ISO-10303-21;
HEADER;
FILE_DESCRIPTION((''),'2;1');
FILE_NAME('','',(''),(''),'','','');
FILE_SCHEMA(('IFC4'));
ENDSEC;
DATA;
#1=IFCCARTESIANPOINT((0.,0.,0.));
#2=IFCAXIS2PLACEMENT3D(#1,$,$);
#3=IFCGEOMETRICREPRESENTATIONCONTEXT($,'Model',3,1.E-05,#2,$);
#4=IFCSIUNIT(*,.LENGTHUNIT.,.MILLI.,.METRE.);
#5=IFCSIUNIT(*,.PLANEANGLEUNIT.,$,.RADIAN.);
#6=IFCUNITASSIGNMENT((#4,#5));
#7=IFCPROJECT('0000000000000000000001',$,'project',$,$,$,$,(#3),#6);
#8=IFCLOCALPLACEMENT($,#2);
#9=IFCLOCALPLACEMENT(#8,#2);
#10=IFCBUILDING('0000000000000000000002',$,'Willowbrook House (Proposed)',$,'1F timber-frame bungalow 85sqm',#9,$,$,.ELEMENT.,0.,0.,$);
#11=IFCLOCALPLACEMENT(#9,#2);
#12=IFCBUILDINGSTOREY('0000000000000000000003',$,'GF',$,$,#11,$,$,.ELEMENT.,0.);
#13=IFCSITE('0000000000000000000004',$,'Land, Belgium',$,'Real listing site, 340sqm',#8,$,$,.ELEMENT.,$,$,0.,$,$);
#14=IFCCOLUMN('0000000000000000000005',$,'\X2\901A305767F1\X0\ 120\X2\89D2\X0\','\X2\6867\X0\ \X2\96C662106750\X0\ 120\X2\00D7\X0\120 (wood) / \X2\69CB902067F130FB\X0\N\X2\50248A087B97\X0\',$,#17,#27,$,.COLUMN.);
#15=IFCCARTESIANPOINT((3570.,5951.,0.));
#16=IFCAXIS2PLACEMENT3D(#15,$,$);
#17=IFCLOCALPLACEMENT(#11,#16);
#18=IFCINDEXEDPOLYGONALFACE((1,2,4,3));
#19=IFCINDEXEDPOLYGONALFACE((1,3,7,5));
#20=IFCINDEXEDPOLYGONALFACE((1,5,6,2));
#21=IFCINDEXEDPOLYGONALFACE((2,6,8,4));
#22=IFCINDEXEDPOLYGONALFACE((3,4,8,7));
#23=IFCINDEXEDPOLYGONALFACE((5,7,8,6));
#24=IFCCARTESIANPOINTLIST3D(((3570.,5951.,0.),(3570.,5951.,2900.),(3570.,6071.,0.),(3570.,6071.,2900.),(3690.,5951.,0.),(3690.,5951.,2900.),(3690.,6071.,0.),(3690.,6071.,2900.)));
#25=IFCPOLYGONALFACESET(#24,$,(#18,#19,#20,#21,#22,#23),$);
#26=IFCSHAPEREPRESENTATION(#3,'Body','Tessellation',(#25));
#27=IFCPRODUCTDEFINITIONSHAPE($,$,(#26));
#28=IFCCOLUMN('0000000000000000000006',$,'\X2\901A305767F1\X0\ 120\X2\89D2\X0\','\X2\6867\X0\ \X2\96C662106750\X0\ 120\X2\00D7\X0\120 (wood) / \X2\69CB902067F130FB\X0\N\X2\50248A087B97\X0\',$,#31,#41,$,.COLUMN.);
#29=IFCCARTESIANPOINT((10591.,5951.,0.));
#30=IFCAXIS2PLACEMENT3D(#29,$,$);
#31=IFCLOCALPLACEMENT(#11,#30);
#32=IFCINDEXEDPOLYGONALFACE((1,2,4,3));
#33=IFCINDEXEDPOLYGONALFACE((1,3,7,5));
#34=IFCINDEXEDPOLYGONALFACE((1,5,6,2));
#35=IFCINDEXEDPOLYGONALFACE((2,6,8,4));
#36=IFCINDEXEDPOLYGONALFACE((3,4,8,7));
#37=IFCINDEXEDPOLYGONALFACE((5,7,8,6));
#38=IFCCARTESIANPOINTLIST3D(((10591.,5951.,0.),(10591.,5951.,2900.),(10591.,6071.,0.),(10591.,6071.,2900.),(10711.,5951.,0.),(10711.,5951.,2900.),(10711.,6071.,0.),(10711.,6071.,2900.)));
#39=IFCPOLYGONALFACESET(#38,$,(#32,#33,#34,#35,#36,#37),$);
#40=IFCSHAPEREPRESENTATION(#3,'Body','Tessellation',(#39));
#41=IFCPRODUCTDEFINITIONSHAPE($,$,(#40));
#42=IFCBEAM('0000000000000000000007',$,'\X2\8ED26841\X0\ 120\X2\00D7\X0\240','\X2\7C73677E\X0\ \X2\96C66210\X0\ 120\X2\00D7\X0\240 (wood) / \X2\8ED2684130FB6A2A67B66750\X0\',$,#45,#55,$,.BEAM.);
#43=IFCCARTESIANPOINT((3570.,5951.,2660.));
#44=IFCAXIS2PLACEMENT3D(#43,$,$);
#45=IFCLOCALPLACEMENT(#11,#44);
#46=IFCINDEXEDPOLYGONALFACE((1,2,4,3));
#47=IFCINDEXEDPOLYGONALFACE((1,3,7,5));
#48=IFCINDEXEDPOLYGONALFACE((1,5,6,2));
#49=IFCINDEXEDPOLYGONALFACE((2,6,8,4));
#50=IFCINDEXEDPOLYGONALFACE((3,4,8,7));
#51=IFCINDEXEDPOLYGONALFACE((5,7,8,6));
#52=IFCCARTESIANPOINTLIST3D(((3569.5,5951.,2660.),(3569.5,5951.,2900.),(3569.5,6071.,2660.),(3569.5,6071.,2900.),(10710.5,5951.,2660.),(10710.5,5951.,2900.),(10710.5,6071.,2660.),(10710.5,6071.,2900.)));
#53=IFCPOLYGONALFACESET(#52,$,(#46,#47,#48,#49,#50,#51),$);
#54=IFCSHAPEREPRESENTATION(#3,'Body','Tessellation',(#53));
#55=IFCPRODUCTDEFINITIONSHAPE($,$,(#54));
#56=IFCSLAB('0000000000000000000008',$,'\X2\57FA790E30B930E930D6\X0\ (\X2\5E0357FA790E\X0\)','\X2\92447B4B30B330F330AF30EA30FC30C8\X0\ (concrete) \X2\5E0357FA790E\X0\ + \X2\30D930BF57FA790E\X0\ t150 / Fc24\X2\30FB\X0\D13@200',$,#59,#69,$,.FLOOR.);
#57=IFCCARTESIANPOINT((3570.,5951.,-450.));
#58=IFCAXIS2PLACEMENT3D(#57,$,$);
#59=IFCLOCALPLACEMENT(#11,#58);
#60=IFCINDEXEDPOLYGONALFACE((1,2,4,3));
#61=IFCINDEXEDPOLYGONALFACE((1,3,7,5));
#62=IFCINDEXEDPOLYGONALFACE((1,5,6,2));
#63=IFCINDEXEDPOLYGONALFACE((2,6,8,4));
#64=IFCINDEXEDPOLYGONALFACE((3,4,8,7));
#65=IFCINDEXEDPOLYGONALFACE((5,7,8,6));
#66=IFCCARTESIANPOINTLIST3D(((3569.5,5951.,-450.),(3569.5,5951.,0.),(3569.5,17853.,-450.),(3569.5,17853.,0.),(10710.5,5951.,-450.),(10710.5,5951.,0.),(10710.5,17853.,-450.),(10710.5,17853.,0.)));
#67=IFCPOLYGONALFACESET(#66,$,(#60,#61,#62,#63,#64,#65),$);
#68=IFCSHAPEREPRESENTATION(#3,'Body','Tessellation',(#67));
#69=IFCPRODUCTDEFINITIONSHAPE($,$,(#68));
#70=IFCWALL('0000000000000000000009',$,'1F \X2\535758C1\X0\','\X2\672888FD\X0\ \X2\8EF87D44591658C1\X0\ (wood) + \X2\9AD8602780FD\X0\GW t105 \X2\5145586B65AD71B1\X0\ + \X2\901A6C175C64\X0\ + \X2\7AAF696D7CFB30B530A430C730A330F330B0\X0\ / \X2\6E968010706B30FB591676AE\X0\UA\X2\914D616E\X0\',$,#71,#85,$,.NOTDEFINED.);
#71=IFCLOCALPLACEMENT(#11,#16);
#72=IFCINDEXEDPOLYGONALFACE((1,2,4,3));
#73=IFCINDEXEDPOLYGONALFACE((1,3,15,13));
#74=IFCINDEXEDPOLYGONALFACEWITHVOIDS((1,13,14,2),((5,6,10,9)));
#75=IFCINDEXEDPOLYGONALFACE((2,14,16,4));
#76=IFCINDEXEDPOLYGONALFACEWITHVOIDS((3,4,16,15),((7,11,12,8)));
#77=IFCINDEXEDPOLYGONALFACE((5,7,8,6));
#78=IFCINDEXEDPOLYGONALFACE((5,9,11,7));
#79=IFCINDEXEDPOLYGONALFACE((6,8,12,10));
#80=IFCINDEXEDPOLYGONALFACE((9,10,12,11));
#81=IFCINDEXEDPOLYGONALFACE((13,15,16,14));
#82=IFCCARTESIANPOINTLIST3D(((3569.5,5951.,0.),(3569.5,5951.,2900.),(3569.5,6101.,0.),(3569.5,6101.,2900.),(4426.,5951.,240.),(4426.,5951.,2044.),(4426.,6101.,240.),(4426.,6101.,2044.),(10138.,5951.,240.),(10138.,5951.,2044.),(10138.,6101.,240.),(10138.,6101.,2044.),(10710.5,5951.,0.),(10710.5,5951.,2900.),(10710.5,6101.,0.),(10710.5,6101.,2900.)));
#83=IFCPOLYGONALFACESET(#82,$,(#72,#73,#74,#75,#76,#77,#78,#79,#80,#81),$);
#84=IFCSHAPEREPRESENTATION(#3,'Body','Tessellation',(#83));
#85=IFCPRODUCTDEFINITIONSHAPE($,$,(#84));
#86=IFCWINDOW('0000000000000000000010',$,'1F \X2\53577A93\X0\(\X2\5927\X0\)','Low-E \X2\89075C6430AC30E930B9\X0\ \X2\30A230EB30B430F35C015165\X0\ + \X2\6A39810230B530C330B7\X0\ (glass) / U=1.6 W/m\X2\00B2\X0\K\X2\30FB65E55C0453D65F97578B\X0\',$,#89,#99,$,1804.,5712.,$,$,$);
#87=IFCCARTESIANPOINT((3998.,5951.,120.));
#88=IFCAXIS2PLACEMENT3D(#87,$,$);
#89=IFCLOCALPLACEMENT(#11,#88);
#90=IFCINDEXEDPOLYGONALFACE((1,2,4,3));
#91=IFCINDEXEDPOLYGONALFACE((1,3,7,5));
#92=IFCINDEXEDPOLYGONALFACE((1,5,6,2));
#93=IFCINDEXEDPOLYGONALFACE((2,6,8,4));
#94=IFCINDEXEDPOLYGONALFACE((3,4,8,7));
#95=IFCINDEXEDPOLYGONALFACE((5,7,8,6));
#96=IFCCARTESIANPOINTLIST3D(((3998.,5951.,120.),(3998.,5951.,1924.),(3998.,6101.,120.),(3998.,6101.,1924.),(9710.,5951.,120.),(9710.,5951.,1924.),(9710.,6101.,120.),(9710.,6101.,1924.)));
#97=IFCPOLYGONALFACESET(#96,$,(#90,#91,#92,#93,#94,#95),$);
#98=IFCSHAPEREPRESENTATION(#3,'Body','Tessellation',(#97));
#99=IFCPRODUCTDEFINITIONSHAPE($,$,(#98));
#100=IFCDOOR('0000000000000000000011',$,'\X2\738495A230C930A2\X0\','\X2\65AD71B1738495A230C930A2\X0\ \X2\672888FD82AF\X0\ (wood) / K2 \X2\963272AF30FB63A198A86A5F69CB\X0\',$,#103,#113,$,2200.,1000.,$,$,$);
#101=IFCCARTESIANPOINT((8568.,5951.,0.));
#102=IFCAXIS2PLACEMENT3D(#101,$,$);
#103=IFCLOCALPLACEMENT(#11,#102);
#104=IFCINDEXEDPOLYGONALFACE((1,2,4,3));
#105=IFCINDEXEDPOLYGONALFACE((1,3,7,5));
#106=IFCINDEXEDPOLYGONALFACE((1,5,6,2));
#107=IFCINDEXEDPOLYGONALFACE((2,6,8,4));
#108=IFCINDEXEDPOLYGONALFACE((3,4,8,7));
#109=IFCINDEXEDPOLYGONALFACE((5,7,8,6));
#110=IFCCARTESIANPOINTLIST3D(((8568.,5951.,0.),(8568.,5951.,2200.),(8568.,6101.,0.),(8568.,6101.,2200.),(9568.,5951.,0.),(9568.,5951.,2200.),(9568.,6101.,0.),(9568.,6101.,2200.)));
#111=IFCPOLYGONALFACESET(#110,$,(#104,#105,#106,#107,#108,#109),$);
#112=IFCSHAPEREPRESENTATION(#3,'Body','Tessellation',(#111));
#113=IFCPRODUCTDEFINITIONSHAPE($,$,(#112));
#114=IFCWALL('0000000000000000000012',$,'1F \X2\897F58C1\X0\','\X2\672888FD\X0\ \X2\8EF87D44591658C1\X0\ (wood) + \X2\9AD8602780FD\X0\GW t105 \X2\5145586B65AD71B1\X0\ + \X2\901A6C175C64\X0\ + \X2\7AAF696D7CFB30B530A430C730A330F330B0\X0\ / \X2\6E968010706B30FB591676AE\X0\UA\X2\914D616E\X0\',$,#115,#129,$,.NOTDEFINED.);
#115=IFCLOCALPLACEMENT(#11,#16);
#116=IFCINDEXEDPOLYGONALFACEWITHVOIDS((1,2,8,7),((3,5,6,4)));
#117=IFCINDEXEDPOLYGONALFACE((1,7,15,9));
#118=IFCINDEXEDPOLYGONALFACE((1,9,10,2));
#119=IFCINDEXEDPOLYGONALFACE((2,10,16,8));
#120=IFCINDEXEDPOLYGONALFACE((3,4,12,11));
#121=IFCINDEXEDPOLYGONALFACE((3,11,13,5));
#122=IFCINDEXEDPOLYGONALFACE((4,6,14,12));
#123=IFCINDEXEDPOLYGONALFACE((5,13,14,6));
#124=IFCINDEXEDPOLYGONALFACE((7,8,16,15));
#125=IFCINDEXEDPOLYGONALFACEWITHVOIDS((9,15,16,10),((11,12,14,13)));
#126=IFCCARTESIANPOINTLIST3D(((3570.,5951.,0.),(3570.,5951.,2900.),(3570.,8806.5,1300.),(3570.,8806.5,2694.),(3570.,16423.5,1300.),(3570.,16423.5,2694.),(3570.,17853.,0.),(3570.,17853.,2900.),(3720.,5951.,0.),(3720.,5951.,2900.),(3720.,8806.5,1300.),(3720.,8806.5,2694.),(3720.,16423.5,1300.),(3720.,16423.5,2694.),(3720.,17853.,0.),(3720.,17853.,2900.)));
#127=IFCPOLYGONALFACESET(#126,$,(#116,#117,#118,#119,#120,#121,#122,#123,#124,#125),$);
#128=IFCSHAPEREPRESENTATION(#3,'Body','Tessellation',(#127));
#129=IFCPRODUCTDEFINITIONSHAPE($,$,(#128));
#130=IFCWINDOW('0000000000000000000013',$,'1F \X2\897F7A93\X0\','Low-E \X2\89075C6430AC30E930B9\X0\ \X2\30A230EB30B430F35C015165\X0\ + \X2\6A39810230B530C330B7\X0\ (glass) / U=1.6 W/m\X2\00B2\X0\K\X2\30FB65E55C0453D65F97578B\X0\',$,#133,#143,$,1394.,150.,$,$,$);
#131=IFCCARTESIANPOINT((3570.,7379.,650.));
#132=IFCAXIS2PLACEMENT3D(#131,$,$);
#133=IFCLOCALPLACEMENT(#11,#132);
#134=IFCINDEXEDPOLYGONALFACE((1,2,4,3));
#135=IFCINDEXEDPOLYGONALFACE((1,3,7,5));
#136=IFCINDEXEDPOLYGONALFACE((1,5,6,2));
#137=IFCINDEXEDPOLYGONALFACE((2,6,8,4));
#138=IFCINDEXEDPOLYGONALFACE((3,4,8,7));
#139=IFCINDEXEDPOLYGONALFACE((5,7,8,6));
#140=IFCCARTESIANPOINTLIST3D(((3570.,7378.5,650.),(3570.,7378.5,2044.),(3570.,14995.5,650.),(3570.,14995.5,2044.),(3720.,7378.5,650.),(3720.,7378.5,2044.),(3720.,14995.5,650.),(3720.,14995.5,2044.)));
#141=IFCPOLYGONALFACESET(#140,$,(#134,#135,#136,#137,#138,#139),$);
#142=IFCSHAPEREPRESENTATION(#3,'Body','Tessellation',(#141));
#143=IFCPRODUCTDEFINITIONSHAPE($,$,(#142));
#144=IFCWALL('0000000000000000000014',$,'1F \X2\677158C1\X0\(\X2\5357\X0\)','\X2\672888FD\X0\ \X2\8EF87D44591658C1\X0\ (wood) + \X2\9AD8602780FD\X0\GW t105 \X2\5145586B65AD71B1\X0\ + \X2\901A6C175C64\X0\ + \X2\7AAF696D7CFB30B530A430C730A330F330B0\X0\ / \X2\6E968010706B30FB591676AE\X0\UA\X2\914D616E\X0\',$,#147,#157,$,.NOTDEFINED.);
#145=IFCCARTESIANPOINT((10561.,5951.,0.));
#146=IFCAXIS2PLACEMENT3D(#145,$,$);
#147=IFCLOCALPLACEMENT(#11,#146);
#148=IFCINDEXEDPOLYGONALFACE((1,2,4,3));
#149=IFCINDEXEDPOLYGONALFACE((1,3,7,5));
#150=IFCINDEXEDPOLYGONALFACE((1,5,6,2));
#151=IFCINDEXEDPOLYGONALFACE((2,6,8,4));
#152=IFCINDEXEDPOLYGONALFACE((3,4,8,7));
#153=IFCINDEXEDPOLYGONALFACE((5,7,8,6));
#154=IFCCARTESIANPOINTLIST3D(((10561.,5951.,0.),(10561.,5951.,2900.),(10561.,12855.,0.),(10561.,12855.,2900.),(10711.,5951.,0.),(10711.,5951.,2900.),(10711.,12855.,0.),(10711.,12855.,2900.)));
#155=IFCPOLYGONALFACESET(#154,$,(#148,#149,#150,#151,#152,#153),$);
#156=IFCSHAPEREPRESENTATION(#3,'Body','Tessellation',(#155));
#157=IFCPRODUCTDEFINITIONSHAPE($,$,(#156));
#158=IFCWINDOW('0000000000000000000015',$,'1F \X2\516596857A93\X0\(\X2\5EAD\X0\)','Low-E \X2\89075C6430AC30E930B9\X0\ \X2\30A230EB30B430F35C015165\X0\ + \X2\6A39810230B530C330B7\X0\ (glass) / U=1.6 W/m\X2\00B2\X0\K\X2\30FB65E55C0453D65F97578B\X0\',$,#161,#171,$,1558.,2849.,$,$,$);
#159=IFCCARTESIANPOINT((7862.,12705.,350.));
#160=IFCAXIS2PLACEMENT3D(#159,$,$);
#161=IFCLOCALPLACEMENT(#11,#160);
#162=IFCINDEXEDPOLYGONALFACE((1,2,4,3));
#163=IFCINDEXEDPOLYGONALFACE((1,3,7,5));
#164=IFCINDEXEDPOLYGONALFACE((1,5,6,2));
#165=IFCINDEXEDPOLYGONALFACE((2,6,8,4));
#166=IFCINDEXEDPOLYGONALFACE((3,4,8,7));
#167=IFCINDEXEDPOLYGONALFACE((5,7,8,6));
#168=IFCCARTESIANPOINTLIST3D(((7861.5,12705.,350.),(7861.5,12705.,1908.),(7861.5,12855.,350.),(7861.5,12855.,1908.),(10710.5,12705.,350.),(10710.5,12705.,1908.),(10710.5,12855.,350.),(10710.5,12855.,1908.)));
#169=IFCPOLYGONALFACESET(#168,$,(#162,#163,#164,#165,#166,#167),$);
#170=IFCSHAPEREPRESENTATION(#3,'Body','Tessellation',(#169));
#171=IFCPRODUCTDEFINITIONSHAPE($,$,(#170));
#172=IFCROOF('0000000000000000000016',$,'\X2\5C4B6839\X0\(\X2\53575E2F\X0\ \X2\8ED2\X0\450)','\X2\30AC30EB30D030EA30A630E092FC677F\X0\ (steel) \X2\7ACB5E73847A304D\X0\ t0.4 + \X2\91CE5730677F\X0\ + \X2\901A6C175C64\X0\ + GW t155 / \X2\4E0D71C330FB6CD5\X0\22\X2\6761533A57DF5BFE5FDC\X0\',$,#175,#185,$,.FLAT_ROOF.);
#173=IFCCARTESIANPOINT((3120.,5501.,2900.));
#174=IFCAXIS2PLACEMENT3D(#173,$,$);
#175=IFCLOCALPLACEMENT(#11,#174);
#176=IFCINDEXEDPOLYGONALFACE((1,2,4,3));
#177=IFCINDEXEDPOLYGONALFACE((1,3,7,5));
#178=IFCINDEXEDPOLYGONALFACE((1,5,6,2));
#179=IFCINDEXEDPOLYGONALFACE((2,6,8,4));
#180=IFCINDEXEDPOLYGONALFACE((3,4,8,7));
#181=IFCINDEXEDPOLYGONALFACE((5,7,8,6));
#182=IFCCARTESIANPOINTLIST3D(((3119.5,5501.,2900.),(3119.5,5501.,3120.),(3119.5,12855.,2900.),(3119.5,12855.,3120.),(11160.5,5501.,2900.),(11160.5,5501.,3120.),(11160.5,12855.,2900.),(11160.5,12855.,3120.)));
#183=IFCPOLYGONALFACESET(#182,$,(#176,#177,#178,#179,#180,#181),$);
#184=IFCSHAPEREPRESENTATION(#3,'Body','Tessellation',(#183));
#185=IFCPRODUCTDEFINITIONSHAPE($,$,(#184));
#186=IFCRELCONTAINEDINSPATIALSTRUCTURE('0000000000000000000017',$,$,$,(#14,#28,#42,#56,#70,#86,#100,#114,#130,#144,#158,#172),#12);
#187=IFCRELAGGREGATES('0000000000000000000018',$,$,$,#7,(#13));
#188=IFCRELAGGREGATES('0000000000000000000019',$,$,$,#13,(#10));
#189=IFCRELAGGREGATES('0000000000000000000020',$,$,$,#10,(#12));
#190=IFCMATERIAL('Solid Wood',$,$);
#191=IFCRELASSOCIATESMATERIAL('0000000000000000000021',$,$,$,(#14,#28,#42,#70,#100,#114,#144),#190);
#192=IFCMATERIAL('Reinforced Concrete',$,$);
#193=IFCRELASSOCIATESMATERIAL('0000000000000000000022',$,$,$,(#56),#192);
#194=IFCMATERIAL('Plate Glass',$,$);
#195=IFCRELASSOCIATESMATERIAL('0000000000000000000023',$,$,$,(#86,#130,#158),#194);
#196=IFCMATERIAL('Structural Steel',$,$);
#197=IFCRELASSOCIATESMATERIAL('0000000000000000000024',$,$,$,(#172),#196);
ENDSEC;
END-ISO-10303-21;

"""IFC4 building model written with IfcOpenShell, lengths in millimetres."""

from ifc_helpers import new_model, si_unit, frame, frame_2d, origin, place, context, project, spatial, rectangle, extrude, material, element, fill, save


model = new_model("IFC4")

# Units and contexts
model_context = context("Model", 3, precision=1e-05, world=origin())
ifc_project = project(units=[si_unit("LENGTHUNIT", "METRE", prefix="MILLI"), si_unit("PLANEANGLEUNIT", "RADIAN")], contexts=[model_context])

# Site, building, storey
site_placement = place(None, origin())
site = spatial("IfcSite", under=ifc_project, at=site_placement, Name="Land, Belgium", ObjectType="Real listing site, 340sqm", CompositionType="ELEMENT", RefElevation=0.0)
building_placement = place(site_placement, origin())
building = spatial("IfcBuilding", under=site, at=building_placement, Name="Willowbrook House (Proposed)", ObjectType="1F timber-frame bungalow 85sqm", CompositionType="ELEMENT", ElevationOfRefHeight=0.0, ElevationOfTerrain=0.0)
storey_placement = place(building_placement, origin())
storey = spatial("IfcBuildingStorey", under=building, at=storey_placement, Name="GF", CompositionType="ELEMENT", Elevation=0.0)

# Columns
ifc_material_1 = material(Name="Solid Wood")
column_1_placement = place(storey_placement, frame((3570.0, 5951.0, 0.0)))
element("IfcColumn", 1, at=column_1_placement, inside=storey, material=ifc_material_1, Name="通し柱 120角", Description="桧 集成材 120×120 (wood) / 構造柱・N値計算", PredefinedType="COLUMN", context=model_context, shape_type="SweptSolid", body=[
    extrude(rectangle(XDim=120.0, YDim=120.0, at=frame_2d((60.0, 60.0))), frame((3570.0, 5951.0, 0.0)), (0.0, 0.0, 1.0), 2900.0),
])
column_2_placement = place(storey_placement, frame((10591.0, 5951.0, 0.0)))
element("IfcColumn", 2, at=column_2_placement, inside=storey, material=ifc_material_1, Name="通し柱 120角", Description="桧 集成材 120×120 (wood) / 構造柱・N値計算", PredefinedType="COLUMN", context=model_context, shape_type="SweptSolid", body=[
    extrude(rectangle(XDim=120.0, YDim=120.0, at=frame_2d((60.0, 60.0))), frame((10591.0, 5951.0, 0.0)), (0.0, 0.0, 1.0), 2900.0),
])

# Beam
beam_1_placement = place(storey_placement, frame((3570.0, 5951.0, 2660.0)))
element("IfcBeam", 3, at=beam_1_placement, inside=storey, material=ifc_material_1, Name="軒桁 120×240", Description="米松 集成 120×240 (wood) / 軒桁・横架材", PredefinedType="BEAM", context=model_context, shape_type="SweptSolid", body=[
    extrude(rectangle(XDim=7141.0, YDim=120.0, at=frame_2d((3570.0, 60.0))), frame((3570.0, 5951.0, 2660.0)), (0.0, 0.0, 1.0), 240.0),
])

# Slab
ifc_material_2 = material(Name="Reinforced Concrete")
slab_1_placement = place(storey_placement, frame((3570.0, 5951.0, -450.0)))
element("IfcSlab", 4, at=slab_1_placement, inside=storey, material=ifc_material_2, Name="基礎スラブ (布基礎)", Description="鉄筋コンクリート (concrete) 布基礎 + ベタ基礎 t150 / Fc24・D13@200", PredefinedType="FLOOR", context=model_context, shape_type="SweptSolid", body=[
    extrude(rectangle(XDim=7141.0, YDim=11902.0, at=frame_2d((3570.0, 5951.0))), frame((3570.0, 5951.0, -450.0)), (0.0, 0.0, 1.0), 450.0),
])

# Wall, openings, window, door
wall_1_placement = place(storey_placement, frame((3570.0, 5951.0, 0.0)))
wall_1 = element("IfcWall", 5, at=wall_1_placement, inside=storey, material=ifc_material_1, Name="1F 南壁", Description="木製 軸組外壁 (wood) + 高性能GW t105 充填断熱 + 通気層 + 窯業系サイディング / 準耐火・外皮UA配慮", PredefinedType="NOTDEFINED", context=model_context, shape_type="SweptSolid", body=[
    extrude(rectangle(XDim=7141.0, YDim=150.0, at=frame_2d((3570.0, 75.0))), frame((3570.0, 5951.0, 0.0)), (0.0, 0.0, 1.0), 2900.0),
])
opening_1_placement = place(storey_placement, frame((3998.0, 5951.0, 120.0)))
opening_1 = element("IfcOpeningElement", 6, at=opening_1_placement, cuts=wall_1, PredefinedType="NOTDEFINED", context=model_context, shape_type="SweptSolid", body=[
    extrude(rectangle(XDim=5712.0, YDim=150.0, at=frame_2d((2856.0, 75.0))), frame((3998.0, 5951.0, 120.0)), (0.0, 0.0, 1.0), 1804.0),
])
opening_2_placement = place(storey_placement, frame((8568.0, 5951.0, 0.0)))
opening_2 = element("IfcOpeningElement", 7, at=opening_2_placement, cuts=wall_1, PredefinedType="NOTDEFINED", context=model_context, shape_type="SweptSolid", body=[
    extrude(rectangle(XDim=1000.0, YDim=150.0, at=frame_2d((500.0, 75.0))), frame((8568.0, 5951.0, 0.0)), (0.0, 0.0, 1.0), 2200.0),
])
ifc_material_3 = material(Name="Plate Glass")
window_1_placement = place(storey_placement, frame((3998.0, 5951.0, 120.0)))
window_1 = element("IfcWindow", 8, at=window_1_placement, inside=storey, material=ifc_material_3, Name="1F 南窓(大)", Description="Low-E 複層ガラス アルゴン封入 + 樹脂サッシ (glass) / U=1.6 W/m²K・日射取得型", OverallHeight=1804.0, OverallWidth=5712.0, context=model_context, shape_type="SweptSolid", body=[
    extrude(rectangle(XDim=5712.0, YDim=150.0, at=frame_2d((2856.0, 75.0))), frame((3998.0, 5951.0, 120.0)), (0.0, 0.0, 1.0), 1804.0),
])
fill(opening_1, window_1)
door_1_placement = place(storey_placement, frame((8568.0, 5951.0, 0.0)))
door_1 = element("IfcDoor", 9, at=door_1_placement, inside=storey, material=ifc_material_1, Name="玄関ドア", Description="断熱玄関ドア 木製芯 (wood) / K2 防犯・採風機構", OverallHeight=2200.0, OverallWidth=1000.0, context=model_context, shape_type="SweptSolid", body=[
    extrude(rectangle(XDim=1000.0, YDim=150.0, at=frame_2d((500.0, 75.0))), frame((8568.0, 5951.0, 0.0)), (0.0, 0.0, 1.0), 2200.0),
])
fill(opening_2, door_1)

# Walls, openings, windows
wall_2_placement = place(storey_placement, frame((3570.0, 5951.0, 0.0)))
wall_2 = element("IfcWall", 10, at=wall_2_placement, inside=storey, material=ifc_material_1, Name="1F 西壁", Description="木製 軸組外壁 (wood) + 高性能GW t105 充填断熱 + 通気層 + 窯業系サイディング / 準耐火・外皮UA配慮", PredefinedType="NOTDEFINED", context=model_context, shape_type="SweptSolid", body=[
    extrude(rectangle(XDim=150.0, YDim=11902.0, at=frame_2d((75.0, 5951.0))), frame((3570.0, 5951.0, 0.0)), (0.0, 0.0, 1.0), 2900.0),
])
opening_3_placement = place(storey_placement, frame((3570.0, 7379.0, 650.0)))
opening_3 = element("IfcOpeningElement", 11, at=opening_3_placement, cuts=wall_2, PredefinedType="NOTDEFINED", context=model_context, shape_type="SweptSolid", body=[
    extrude(rectangle(XDim=150.0, YDim=7617.0, at=frame_2d((75.0, 3808.0))), frame((3570.0, 7379.0, 650.0)), (0.0, 0.0, 1.0), 1394.0),
])
window_2_placement = place(storey_placement, frame((3570.0, 7379.0, 650.0)))
window_2 = element("IfcWindow", 12, at=window_2_placement, inside=storey, material=ifc_material_3, Name="1F 西窓", Description="Low-E 複層ガラス アルゴン封入 + 樹脂サッシ (glass) / U=1.6 W/m²K・日射取得型", OverallHeight=1394.0, OverallWidth=150.0, context=model_context, shape_type="SweptSolid", body=[
    extrude(rectangle(XDim=150.0, YDim=7617.0, at=frame_2d((75.0, 3808.0))), frame((3570.0, 7379.0, 650.0)), (0.0, 0.0, 1.0), 1394.0),
])
fill(opening_3, window_2)
wall_3_placement = place(storey_placement, frame((10561.0, 5951.0, 0.0)))
wall_3 = element("IfcWall", 13, at=wall_3_placement, inside=storey, material=ifc_material_1, Name="1F 東壁(南)", Description="木製 軸組外壁 (wood) + 高性能GW t105 充填断熱 + 通気層 + 窯業系サイディング / 準耐火・外皮UA配慮", PredefinedType="NOTDEFINED", context=model_context, shape_type="SweptSolid", body=[
    extrude(rectangle(XDim=150.0, YDim=6904.0, at=frame_2d((75.0, 3452.0))), frame((10561.0, 5951.0, 0.0)), (0.0, 0.0, 1.0), 2900.0),
])
opening_4_placement = place(storey_placement, frame((7862.0, 12705.0, 350.0)))
opening_4 = element("IfcOpeningElement", 14, at=opening_4_placement, cuts=wall_3, PredefinedType="NOTDEFINED", context=model_context, shape_type="SweptSolid", body=[
    extrude(rectangle(XDim=2849.0, YDim=150.0, at=frame_2d((1424.0, 75.0))), frame((7862.0, 12705.0, 350.0)), (0.0, 0.0, 1.0), 1558.0),
])
window_3_placement = place(storey_placement, frame((7862.0, 12705.0, 350.0)))
window_3 = element("IfcWindow", 15, at=window_3_placement, inside=storey, material=ifc_material_3, Name="1F 入隅窓(庭)", Description="Low-E 複層ガラス アルゴン封入 + 樹脂サッシ (glass) / U=1.6 W/m²K・日射取得型", OverallHeight=1558.0, OverallWidth=2849.0, context=model_context, shape_type="SweptSolid", body=[
    extrude(rectangle(XDim=2849.0, YDim=150.0, at=frame_2d((1424.0, 75.0))), frame((7862.0, 12705.0, 350.0)), (0.0, 0.0, 1.0), 1558.0),
])
fill(opening_4, window_3)

# Roof
ifc_material_4 = material(Name="Structural Steel")
roof_placement = place(storey_placement, frame((3120.0, 5501.0, 2900.0)))
element("IfcRoof", 16, at=roof_placement, inside=storey, material=ifc_material_4, Name="屋根(南帯 軒450)", Description="ガルバリウム鋼板 (steel) 立平葺き t0.4 + 野地板 + 通気層 + GW t155 / 不燃・法22条区域対応", PredefinedType="FLAT_ROOF", context=model_context, shape_type="SweptSolid", body=[
    extrude(rectangle(XDim=8041.0, YDim=7354.0, at=frame_2d((4020.0, 3677.0))), frame((3120.0, 5501.0, 2900.0)), (0.0, 0.0, 1.0), 220.0),
])

save(model, "model.ifc")
